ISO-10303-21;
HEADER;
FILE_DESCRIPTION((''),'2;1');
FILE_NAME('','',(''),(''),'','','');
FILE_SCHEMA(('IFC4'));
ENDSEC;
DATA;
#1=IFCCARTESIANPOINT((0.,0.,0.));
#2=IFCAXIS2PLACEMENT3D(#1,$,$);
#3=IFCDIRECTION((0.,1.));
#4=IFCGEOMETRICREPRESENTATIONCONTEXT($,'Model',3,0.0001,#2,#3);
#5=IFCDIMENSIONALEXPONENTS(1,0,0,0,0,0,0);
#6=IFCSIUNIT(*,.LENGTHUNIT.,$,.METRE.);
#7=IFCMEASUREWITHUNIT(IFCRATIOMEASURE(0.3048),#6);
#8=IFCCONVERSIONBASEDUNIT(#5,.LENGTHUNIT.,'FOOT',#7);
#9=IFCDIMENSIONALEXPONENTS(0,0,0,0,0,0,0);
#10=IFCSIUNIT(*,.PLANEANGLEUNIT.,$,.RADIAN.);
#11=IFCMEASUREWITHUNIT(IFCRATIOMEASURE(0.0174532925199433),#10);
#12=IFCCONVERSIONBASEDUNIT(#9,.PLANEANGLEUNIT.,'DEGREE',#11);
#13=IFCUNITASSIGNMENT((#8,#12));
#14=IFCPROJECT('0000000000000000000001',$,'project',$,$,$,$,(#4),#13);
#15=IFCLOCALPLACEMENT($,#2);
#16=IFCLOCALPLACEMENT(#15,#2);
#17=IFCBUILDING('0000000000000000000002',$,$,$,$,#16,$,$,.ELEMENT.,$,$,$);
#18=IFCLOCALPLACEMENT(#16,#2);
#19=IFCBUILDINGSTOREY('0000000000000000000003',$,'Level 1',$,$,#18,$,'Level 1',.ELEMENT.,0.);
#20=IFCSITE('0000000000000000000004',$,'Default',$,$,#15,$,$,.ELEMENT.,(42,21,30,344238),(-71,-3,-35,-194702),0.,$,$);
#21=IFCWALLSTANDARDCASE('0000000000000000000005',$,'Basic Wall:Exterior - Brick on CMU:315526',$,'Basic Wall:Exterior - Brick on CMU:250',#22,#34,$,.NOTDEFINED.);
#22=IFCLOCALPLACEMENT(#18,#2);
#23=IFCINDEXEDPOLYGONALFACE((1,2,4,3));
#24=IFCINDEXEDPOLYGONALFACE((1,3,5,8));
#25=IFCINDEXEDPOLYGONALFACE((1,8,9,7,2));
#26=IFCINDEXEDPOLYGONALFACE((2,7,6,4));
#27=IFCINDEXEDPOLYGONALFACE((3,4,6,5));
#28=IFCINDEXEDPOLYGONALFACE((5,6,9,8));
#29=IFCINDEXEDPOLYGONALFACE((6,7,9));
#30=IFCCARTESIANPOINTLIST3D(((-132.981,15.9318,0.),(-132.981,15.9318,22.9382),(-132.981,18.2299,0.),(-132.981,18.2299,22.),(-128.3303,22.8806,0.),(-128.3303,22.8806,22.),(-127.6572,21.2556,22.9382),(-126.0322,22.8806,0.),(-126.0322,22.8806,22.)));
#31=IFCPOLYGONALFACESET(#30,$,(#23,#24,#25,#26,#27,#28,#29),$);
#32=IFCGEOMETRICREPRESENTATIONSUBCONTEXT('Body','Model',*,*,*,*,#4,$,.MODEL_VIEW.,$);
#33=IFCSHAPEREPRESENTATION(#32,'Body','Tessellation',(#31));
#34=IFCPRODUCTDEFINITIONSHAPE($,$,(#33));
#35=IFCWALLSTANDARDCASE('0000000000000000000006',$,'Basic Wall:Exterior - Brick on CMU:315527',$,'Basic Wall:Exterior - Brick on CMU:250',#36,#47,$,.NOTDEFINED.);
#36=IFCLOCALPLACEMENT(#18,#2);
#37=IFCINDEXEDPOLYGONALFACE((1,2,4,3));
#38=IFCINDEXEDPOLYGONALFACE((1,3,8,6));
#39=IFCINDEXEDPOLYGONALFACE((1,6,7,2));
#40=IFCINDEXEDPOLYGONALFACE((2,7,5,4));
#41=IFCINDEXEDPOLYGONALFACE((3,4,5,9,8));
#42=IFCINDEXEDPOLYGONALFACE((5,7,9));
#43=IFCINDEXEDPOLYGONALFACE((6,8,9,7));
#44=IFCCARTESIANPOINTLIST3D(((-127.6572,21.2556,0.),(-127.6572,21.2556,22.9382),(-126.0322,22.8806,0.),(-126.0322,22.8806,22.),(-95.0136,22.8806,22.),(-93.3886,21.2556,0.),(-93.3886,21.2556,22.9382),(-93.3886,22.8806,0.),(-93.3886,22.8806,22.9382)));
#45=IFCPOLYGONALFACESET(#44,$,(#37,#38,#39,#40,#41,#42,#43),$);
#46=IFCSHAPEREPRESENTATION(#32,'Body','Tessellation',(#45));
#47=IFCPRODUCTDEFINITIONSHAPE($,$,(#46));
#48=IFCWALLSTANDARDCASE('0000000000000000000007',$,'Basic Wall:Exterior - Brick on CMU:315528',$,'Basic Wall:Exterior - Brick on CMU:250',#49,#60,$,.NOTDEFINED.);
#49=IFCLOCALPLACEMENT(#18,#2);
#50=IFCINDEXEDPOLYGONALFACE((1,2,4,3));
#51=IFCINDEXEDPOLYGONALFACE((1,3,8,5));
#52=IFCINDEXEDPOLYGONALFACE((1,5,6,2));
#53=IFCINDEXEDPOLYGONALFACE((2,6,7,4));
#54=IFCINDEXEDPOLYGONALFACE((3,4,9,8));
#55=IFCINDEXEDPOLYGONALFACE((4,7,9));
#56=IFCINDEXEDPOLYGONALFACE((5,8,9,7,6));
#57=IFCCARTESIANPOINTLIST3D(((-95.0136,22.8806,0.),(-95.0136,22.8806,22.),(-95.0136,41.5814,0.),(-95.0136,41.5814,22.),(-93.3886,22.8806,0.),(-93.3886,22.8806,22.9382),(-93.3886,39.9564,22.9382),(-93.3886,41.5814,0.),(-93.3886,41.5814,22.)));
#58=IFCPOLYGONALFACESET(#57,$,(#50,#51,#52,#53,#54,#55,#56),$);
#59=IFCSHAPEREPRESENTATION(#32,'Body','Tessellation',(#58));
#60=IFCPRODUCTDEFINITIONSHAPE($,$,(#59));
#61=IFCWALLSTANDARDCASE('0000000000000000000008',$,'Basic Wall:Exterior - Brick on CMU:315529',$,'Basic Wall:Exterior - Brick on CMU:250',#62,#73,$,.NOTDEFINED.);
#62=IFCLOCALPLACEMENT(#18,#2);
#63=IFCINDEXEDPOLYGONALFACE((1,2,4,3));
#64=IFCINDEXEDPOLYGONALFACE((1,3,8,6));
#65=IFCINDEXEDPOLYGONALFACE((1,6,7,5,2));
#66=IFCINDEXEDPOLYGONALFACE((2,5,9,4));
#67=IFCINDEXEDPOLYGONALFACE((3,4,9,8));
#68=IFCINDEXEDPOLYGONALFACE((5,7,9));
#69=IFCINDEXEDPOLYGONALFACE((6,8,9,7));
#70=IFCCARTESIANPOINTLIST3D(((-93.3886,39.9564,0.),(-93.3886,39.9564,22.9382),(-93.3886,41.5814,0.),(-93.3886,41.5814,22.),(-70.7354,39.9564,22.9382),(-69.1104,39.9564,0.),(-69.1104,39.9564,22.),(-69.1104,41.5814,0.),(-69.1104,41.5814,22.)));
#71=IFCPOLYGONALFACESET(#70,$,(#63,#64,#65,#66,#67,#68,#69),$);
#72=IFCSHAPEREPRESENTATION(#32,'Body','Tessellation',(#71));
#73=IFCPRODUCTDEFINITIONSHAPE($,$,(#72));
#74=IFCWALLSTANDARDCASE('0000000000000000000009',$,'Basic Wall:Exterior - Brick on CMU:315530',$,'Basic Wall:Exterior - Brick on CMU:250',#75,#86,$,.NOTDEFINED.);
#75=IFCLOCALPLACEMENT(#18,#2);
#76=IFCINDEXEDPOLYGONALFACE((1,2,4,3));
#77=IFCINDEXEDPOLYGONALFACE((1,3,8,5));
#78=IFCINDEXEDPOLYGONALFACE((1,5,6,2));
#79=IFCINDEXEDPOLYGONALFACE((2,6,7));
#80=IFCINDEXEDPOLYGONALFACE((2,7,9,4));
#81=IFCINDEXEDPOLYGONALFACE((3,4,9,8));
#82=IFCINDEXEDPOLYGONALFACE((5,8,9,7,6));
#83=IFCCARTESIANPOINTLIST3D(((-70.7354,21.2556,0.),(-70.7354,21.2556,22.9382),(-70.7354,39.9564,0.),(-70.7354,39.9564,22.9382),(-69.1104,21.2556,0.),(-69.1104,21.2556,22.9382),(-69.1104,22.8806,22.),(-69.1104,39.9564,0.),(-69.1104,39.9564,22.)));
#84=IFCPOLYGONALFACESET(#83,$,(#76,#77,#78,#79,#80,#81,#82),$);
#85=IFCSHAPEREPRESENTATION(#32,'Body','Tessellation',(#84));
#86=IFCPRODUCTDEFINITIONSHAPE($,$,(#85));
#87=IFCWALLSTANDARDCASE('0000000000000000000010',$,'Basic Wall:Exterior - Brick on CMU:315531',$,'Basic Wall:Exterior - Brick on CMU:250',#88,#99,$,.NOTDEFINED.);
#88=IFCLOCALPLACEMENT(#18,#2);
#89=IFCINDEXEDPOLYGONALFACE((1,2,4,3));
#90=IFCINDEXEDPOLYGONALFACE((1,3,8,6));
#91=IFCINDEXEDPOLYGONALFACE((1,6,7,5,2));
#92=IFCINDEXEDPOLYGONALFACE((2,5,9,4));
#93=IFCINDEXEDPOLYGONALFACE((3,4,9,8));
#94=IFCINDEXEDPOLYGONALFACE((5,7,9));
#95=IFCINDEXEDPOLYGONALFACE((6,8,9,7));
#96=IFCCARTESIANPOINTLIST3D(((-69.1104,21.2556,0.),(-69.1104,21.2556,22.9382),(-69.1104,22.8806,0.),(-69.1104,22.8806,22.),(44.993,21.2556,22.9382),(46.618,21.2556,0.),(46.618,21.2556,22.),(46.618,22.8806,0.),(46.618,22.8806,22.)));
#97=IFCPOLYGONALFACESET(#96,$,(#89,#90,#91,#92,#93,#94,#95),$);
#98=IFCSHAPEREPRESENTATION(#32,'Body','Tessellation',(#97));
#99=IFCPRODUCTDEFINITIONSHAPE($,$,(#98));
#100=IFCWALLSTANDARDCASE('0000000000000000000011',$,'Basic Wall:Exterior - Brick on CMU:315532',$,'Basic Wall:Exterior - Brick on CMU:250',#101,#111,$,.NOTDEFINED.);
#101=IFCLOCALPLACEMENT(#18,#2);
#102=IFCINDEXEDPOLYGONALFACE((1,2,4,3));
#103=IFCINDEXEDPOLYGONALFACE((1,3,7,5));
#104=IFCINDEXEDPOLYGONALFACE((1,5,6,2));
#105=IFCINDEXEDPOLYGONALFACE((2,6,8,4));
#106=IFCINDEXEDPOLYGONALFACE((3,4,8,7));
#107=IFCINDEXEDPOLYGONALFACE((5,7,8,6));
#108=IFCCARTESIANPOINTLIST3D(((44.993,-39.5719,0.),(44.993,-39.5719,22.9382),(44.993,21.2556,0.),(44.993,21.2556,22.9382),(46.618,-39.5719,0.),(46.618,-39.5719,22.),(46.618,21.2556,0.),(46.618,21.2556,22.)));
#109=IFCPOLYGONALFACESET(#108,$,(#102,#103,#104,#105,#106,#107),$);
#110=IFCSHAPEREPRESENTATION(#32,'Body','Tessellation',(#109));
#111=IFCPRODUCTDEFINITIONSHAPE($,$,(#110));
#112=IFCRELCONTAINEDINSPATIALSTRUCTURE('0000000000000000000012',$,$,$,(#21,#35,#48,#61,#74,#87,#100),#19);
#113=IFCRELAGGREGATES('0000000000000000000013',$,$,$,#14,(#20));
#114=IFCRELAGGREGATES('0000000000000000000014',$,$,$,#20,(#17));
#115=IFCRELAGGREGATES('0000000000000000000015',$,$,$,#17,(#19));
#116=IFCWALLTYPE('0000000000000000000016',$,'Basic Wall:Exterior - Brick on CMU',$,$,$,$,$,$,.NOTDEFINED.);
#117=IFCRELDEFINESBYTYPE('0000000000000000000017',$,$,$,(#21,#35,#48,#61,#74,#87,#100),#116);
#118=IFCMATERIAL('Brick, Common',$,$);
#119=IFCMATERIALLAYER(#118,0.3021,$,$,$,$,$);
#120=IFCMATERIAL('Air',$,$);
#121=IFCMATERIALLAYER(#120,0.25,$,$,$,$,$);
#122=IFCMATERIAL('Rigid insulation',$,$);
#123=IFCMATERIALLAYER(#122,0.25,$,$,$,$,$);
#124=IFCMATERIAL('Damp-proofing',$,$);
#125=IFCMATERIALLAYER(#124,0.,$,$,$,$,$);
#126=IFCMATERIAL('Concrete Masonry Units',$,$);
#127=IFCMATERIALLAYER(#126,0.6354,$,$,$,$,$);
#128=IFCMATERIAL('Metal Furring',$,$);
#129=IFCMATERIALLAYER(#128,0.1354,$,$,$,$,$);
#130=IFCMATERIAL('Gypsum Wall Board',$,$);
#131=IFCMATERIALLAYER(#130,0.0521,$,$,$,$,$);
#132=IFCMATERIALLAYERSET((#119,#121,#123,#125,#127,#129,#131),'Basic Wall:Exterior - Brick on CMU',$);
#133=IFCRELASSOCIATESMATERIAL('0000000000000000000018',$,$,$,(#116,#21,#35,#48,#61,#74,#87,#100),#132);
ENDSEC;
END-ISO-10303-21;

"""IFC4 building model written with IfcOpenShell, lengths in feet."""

from ifc_helpers import new_model, entity, si_unit, converted_unit, direction, frame, frame_2d, origin, place, context, subcontext, project, spatial, polyline, rectangle, outline, extrude, clip, bounded_halfspace, material, layer, layer_set, layer_usage, type_object, element, save


model = new_model("IFC4")

# Units and contexts
model_context = context("Model", 3, precision=0.0001, world=origin(), true_north=direction((0.0, 1.0)))
body_context = subcontext(model_context, "Body", "Model", "MODEL_VIEW")
ifc_project = project(units=[converted_unit("LENGTHUNIT", "FOOT", entity("IfcRatioMeasure", 0.3048), si_unit("LENGTHUNIT", "METRE"), dimensions=[1, 0, 0, 0, 0, 0, 0]), converted_unit("PLANEANGLEUNIT", "DEGREE", entity("IfcRatioMeasure", 0.0174532925199433), si_unit("PLANEANGLEUNIT", "RADIAN"), dimensions=[0, 0, 0, 0, 0, 0, 0])], contexts=[model_context])

# Site, building, storey
site_placement = place(None, origin())
site = spatial("IfcSite", under=ifc_project, at=site_placement, Name="Default", CompositionType="ELEMENT", RefLatitude=(42, 21, 30, 344238), RefLongitude=(-71, -3, -35, -194702), RefElevation=0.0)
building_placement = place(site_placement, origin())
building = spatial("IfcBuilding", under=site, at=building_placement, CompositionType="ELEMENT")
storey_placement = place(building_placement, origin())
storey = spatial("IfcBuildingStorey", under=building, at=storey_placement, Name="Level 1", LongName="Level 1", CompositionType="ELEMENT", Elevation=0.0)

# Shared definitions
wall_1_placement = place(storey_placement, frame((45.8055, 21.2556, 0.0), z_axis=(0.0, 0.0, 1.0), x_axis=(0.0, -1.0, 0.0)))

# Walls
ifc_material_1 = material(Name="Brick, Common")
ifc_layer_1 = layer(ifc_material_1, 0.3021)
ifc_material_2 = material(Name="Air")
ifc_layer_2 = layer(ifc_material_2, 0.25)
ifc_material_3 = material(Name="Rigid insulation")
ifc_layer_3 = layer(ifc_material_3, 0.25)
ifc_material_4 = material(Name="Damp-proofing")
ifc_layer_4 = layer(ifc_material_4, 0.0)
ifc_material_5 = material(Name="Concrete Masonry Units")
ifc_layer_5 = layer(ifc_material_5, 0.6354)
ifc_material_6 = material(Name="Metal Furring")
ifc_layer_6 = layer(ifc_material_6, 0.1354)
ifc_material_7 = material(Name="Gypsum Wall Board")
ifc_layer_7 = layer(ifc_material_7, 0.0521)
ifc_layer_set = layer_set([ifc_layer_1, ifc_layer_2, ifc_layer_3, ifc_layer_4, ifc_layer_5, ifc_layer_6, ifc_layer_7], Name="Basic Wall:Exterior - Brick on CMU")
wall_type = type_object("IfcWallType", Name="Basic Wall:Exterior - Brick on CMU", PredefinedType="NOTDEFINED", material=ifc_layer_set)
ifc_layer_usage_1 = layer_usage(ifc_layer_set, "AXIS2", "POSITIVE", -0.8125)
wall_2_placement = place(storey_placement, frame((-126.6067, 23.4552, 0.0), z_axis=(0.0, 0.0, 1.0), x_axis=(-0.707107, -0.707107, 0.0)))
element("IfcWallStandardCase", 1, at=wall_2_placement, inside=storey, type_object=wall_type, material=ifc_layer_usage_1, Name="Basic Wall:Exterior - Brick on CMU:315526", ObjectType="Basic Wall:Exterior - Brick on CMU:250", PredefinedType="NOTDEFINED", context=body_context, shape_type="Clipping", body=[
    clip(clip(extrude(outline(polyline([(8.2021, -0.8125), (9.8271, 0.8125), (2.2981, 0.8125), (0.0, 0.8125), (1.625, -0.8125), (8.2021, -0.8125)])), origin(), (0.0, 0.0, 1.0), 22.9382), bounded_halfspace(frame((2.2981, 0.8125, 22.9382), z_axis=(-0.353553, -0.353553, 0.866025), x_axis=(0.707107, -0.707107, 0.0)), False, frame((2.2981, 0.8125, 22.9382)), polyline([(0.0, 0.0), (-2.2981, 0.0), (-0.6731, -1.625), (0.0, 0.0)]))), bounded_halfspace(frame((1.625, -0.8125, 22.0), z_axis=(0.0, -0.5, 0.866025), x_axis=(1.0, 0.0, 0.0)), False, frame((1.625, -0.8125, 22.0)), polyline([(0.0, 0.0), (6.5771, 0.0), (8.2021, 1.625), (0.6731, 1.625), (0.0, 0.0)]))),
])
ifc_layer_usage_2 = layer_usage(ifc_layer_set, "AXIS2", "NEGATIVE", 0.8125)
wall_3_placement = place(storey_placement, frame((-127.6572, 22.0681, 0.0)))
element("IfcWallStandardCase", 2, at=wall_3_placement, inside=storey, type_object=wall_type, material=ifc_layer_usage_2, Name="Basic Wall:Exterior - Brick on CMU:315527", ObjectType="Basic Wall:Exterior - Brick on CMU:250", PredefinedType="NOTDEFINED", context=body_context, shape_type="Clipping", body=[
    clip(clip(extrude(outline(polyline([(34.2686, -0.8125), (34.2686, 0.8125), (32.6436, 0.8125), (1.625, 0.8125), (0.0, -0.8125), (34.2686, -0.8125)])), origin(), (0.0, 0.0, 1.0), 22.9382), bounded_halfspace(frame((0.0, -0.8125, 22.9382), z_axis=(0.0, 0.5, 0.866025), x_axis=(-1.0, 0.0, 0.0)), False, frame((0.0, -0.8125, 22.9382)), polyline([(0.0, 0.0), (34.2686, 0.0), (32.6436, 1.625), (1.625, 1.625), (0.0, 0.0)]))), bounded_halfspace(frame((34.2686, -0.8125, 22.9382), z_axis=(-0.5, 0.0, 0.866025), x_axis=(0.0, -1.0, 0.0)), False, frame((34.2686, -0.8125, 22.9382)), polyline([(0.0, 0.0), (0.0, 1.625), (-1.625, 1.625), (0.0, 0.0)]))),
])
ifc_layer_usage_3 = layer_usage(ifc_layer_set, "AXIS2", "NEGATIVE", 0.8125)
wall_4_placement = place(storey_placement, frame((-94.2011, 22.8806, 0.0), z_axis=(0.0, 0.0, 1.0), x_axis=(0.0, 1.0, 0.0)))
element("IfcWallStandardCase", 3, at=wall_4_placement, inside=storey, type_object=wall_type, material=ifc_layer_usage_3, Name="Basic Wall:Exterior - Brick on CMU:315528", ObjectType="Basic Wall:Exterior - Brick on CMU:250", PredefinedType="NOTDEFINED", context=body_context, shape_type="Clipping", body=[
    clip(clip(extrude(rectangle(XDim=18.7008, YDim=1.625, at=frame_2d((9.3504, 0.0), x_axis=(-1.0, 0.0))), origin(), (0.0, 0.0, 1.0), 22.9382), bounded_halfspace(frame((17.0758, -0.8125, 22.9382), z_axis=(0.5, 0.0, 0.866025), x_axis=(0.0, 1.0, 0.0)), False, frame((17.0758, -0.8125, 22.9382)), polyline([(0.0, 0.0), (1.625, 0.0), (1.625, 1.625), (0.0, 0.0)]))), bounded_halfspace(frame((0.0, -0.8125, 22.9382), z_axis=(0.0, 0.5, 0.866025), x_axis=(-1.0, 0.0, 0.0)), False, frame((0.0, -0.8125, 22.9382)), polyline([(0.0, 0.0), (17.0758, 0.0), (18.7008, 1.625), (0.0, 1.625), (0.0, 0.0)]))),
])
ifc_layer_usage_4 = layer_usage(ifc_layer_set, "AXIS2", "NEGATIVE", 0.8125)
wall_5_placement = place(storey_placement, frame((-93.3886, 40.7689, 0.0)))
element("IfcWallStandardCase", 4, at=wall_5_placement, inside=storey, type_object=wall_type, material=ifc_layer_usage_4, Name="Basic Wall:Exterior - Brick on CMU:315529", ObjectType="Basic Wall:Exterior - Brick on CMU:250", PredefinedType="NOTDEFINED", context=body_context, shape_type="Clipping", body=[
    clip(clip(extrude(rectangle(XDim=24.2782, YDim=1.625, at=frame_2d((12.1391, 0.0), x_axis=(-1.0, 0.0))), origin(), (0.0, 0.0, 1.0), 22.9382), bounded_halfspace(frame((0.0, -0.8125, 22.9382), z_axis=(0.0, 0.5, 0.866025), x_axis=(-1.0, 0.0, 0.0)), False, frame((0.0, -0.8125, 22.9382)), polyline([(0.0, 0.0), (22.6532, 0.0), (24.2782, 1.625), (0.0, 1.625), (0.0, 0.0)]))), bounded_halfspace(frame((22.6532, -0.8125, 22.9382), z_axis=(0.5, 0.0, 0.866025), x_axis=(0.0, 1.0, 0.0)), False, frame((22.6532, -0.8125, 22.9382)), polyline([(0.0, 0.0), (1.625, 0.0), (1.625, 1.625), (0.0, 0.0)]))),
])
ifc_layer_usage_5 = layer_usage(ifc_layer_set, "AXIS2", "NEGATIVE", 0.8125)
wall_6_placement = place(storey_placement, frame((-69.9229, 39.9564, 0.0), z_axis=(0.0, 0.0, 1.0), x_axis=(0.0, -1.0, 0.0)))
element("IfcWallStandardCase", 5, at=wall_6_placement, inside=storey, type_object=wall_type, material=ifc_layer_usage_5, Name="Basic Wall:Exterior - Brick on CMU:315530", ObjectType="Basic Wall:Exterior - Brick on CMU:250", PredefinedType="NOTDEFINED", context=body_context, shape_type="Clipping", body=[
    clip(clip(extrude(rectangle(XDim=18.7008, YDim=1.625, at=frame_2d((9.3504, 0.0), x_axis=(-1.0, 0.0))), origin(), (0.0, 0.0, 1.0), 22.9382), bounded_halfspace(frame((18.7008, -0.8125, 22.9382), z_axis=(-0.5, 0.0, 0.866025), x_axis=(0.0, -1.0, 0.0)), False, frame((18.7008, -0.8125, 22.9382)), polyline([(0.0, 0.0), (0.0, 1.625), (-1.625, 1.625), (0.0, 0.0)]))), bounded_halfspace(frame((0.0, -0.8125, 22.9382), z_axis=(0.0, 0.5, 0.866025), x_axis=(-1.0, 0.0, 0.0)), False, frame((0.0, -0.8125, 22.9382)), polyline([(0.0, 0.0), (18.7008, 0.0), (17.0758, 1.625), (0.0, 1.625), (0.0, 0.0)]))),
])
ifc_layer_usage_6 = layer_usage(ifc_layer_set, "AXIS2", "NEGATIVE", 0.8125)
wall_7_placement = place(storey_placement, frame((-69.1104, 22.0681, 0.0)))
element("IfcWallStandardCase", 6, at=wall_7_placement, inside=storey, type_object=wall_type, material=ifc_layer_usage_6, Name="Basic Wall:Exterior - Brick on CMU:315531", ObjectType="Basic Wall:Exterior - Brick on CMU:250", PredefinedType="NOTDEFINED", context=body_context, shape_type="Clipping", body=[
    clip(clip(extrude(rectangle(XDim=115.7284, YDim=1.625, at=frame_2d((57.8642, 0.0), x_axis=(-1.0, 0.0))), origin(), (0.0, 0.0, 1.0), 22.9382), bounded_halfspace(frame((114.1034, -0.8125, 22.9382), z_axis=(0.5, 0.0, 0.866025), x_axis=(0.0, 1.0, 0.0)), False, frame((114.1034, -0.8125, 22.9382)), polyline([(0.0, 0.0), (1.625, 0.0), (1.625, 1.625), (0.0, 0.0)]))), bounded_halfspace(frame((0.0, -0.8125, 22.9382), z_axis=(0.0, 0.5, 0.866025), x_axis=(-1.0, 0.0, 0.0)), False, frame((0.0, -0.8125, 22.9382)), polyline([(0.0, 0.0), (114.1034, 0.0), (115.7284, 1.625), (0.0, 1.625), (0.0, 0.0)]))),
])
ifc_layer_usage_7 = layer_usage(ifc_layer_set, "AXIS2", "NEGATIVE", 0.8125)
element("IfcWallStandardCase", 7, at=wall_1_placement, inside=storey, type_object=wall_type, material=ifc_layer_usage_7, Name="Basic Wall:Exterior - Brick on CMU:315532", ObjectType="Basic Wall:Exterior - Brick on CMU:250", PredefinedType="NOTDEFINED", context=body_context, shape_type="Clipping", body=[
    clip(extrude(rectangle(XDim=60.8275, YDim=1.625, at=frame_2d((30.4138, 0.0), x_axis=(-1.0, 0.0))), origin(), (0.0, 0.0, 1.0), 22.9382), bounded_halfspace(frame((0.0, -0.8125, 22.9382), z_axis=(0.0, 0.5, 0.866025), x_axis=(-1.0, 0.0, 0.0)), False, frame((0.0, -0.8125, 22.9382)), polyline([(0.0, 0.0), (60.8275, 0.0), (60.8275, 1.625), (0.0, 1.625), (0.0, 0.0)]))),
])

save(model, "model.ifc")
